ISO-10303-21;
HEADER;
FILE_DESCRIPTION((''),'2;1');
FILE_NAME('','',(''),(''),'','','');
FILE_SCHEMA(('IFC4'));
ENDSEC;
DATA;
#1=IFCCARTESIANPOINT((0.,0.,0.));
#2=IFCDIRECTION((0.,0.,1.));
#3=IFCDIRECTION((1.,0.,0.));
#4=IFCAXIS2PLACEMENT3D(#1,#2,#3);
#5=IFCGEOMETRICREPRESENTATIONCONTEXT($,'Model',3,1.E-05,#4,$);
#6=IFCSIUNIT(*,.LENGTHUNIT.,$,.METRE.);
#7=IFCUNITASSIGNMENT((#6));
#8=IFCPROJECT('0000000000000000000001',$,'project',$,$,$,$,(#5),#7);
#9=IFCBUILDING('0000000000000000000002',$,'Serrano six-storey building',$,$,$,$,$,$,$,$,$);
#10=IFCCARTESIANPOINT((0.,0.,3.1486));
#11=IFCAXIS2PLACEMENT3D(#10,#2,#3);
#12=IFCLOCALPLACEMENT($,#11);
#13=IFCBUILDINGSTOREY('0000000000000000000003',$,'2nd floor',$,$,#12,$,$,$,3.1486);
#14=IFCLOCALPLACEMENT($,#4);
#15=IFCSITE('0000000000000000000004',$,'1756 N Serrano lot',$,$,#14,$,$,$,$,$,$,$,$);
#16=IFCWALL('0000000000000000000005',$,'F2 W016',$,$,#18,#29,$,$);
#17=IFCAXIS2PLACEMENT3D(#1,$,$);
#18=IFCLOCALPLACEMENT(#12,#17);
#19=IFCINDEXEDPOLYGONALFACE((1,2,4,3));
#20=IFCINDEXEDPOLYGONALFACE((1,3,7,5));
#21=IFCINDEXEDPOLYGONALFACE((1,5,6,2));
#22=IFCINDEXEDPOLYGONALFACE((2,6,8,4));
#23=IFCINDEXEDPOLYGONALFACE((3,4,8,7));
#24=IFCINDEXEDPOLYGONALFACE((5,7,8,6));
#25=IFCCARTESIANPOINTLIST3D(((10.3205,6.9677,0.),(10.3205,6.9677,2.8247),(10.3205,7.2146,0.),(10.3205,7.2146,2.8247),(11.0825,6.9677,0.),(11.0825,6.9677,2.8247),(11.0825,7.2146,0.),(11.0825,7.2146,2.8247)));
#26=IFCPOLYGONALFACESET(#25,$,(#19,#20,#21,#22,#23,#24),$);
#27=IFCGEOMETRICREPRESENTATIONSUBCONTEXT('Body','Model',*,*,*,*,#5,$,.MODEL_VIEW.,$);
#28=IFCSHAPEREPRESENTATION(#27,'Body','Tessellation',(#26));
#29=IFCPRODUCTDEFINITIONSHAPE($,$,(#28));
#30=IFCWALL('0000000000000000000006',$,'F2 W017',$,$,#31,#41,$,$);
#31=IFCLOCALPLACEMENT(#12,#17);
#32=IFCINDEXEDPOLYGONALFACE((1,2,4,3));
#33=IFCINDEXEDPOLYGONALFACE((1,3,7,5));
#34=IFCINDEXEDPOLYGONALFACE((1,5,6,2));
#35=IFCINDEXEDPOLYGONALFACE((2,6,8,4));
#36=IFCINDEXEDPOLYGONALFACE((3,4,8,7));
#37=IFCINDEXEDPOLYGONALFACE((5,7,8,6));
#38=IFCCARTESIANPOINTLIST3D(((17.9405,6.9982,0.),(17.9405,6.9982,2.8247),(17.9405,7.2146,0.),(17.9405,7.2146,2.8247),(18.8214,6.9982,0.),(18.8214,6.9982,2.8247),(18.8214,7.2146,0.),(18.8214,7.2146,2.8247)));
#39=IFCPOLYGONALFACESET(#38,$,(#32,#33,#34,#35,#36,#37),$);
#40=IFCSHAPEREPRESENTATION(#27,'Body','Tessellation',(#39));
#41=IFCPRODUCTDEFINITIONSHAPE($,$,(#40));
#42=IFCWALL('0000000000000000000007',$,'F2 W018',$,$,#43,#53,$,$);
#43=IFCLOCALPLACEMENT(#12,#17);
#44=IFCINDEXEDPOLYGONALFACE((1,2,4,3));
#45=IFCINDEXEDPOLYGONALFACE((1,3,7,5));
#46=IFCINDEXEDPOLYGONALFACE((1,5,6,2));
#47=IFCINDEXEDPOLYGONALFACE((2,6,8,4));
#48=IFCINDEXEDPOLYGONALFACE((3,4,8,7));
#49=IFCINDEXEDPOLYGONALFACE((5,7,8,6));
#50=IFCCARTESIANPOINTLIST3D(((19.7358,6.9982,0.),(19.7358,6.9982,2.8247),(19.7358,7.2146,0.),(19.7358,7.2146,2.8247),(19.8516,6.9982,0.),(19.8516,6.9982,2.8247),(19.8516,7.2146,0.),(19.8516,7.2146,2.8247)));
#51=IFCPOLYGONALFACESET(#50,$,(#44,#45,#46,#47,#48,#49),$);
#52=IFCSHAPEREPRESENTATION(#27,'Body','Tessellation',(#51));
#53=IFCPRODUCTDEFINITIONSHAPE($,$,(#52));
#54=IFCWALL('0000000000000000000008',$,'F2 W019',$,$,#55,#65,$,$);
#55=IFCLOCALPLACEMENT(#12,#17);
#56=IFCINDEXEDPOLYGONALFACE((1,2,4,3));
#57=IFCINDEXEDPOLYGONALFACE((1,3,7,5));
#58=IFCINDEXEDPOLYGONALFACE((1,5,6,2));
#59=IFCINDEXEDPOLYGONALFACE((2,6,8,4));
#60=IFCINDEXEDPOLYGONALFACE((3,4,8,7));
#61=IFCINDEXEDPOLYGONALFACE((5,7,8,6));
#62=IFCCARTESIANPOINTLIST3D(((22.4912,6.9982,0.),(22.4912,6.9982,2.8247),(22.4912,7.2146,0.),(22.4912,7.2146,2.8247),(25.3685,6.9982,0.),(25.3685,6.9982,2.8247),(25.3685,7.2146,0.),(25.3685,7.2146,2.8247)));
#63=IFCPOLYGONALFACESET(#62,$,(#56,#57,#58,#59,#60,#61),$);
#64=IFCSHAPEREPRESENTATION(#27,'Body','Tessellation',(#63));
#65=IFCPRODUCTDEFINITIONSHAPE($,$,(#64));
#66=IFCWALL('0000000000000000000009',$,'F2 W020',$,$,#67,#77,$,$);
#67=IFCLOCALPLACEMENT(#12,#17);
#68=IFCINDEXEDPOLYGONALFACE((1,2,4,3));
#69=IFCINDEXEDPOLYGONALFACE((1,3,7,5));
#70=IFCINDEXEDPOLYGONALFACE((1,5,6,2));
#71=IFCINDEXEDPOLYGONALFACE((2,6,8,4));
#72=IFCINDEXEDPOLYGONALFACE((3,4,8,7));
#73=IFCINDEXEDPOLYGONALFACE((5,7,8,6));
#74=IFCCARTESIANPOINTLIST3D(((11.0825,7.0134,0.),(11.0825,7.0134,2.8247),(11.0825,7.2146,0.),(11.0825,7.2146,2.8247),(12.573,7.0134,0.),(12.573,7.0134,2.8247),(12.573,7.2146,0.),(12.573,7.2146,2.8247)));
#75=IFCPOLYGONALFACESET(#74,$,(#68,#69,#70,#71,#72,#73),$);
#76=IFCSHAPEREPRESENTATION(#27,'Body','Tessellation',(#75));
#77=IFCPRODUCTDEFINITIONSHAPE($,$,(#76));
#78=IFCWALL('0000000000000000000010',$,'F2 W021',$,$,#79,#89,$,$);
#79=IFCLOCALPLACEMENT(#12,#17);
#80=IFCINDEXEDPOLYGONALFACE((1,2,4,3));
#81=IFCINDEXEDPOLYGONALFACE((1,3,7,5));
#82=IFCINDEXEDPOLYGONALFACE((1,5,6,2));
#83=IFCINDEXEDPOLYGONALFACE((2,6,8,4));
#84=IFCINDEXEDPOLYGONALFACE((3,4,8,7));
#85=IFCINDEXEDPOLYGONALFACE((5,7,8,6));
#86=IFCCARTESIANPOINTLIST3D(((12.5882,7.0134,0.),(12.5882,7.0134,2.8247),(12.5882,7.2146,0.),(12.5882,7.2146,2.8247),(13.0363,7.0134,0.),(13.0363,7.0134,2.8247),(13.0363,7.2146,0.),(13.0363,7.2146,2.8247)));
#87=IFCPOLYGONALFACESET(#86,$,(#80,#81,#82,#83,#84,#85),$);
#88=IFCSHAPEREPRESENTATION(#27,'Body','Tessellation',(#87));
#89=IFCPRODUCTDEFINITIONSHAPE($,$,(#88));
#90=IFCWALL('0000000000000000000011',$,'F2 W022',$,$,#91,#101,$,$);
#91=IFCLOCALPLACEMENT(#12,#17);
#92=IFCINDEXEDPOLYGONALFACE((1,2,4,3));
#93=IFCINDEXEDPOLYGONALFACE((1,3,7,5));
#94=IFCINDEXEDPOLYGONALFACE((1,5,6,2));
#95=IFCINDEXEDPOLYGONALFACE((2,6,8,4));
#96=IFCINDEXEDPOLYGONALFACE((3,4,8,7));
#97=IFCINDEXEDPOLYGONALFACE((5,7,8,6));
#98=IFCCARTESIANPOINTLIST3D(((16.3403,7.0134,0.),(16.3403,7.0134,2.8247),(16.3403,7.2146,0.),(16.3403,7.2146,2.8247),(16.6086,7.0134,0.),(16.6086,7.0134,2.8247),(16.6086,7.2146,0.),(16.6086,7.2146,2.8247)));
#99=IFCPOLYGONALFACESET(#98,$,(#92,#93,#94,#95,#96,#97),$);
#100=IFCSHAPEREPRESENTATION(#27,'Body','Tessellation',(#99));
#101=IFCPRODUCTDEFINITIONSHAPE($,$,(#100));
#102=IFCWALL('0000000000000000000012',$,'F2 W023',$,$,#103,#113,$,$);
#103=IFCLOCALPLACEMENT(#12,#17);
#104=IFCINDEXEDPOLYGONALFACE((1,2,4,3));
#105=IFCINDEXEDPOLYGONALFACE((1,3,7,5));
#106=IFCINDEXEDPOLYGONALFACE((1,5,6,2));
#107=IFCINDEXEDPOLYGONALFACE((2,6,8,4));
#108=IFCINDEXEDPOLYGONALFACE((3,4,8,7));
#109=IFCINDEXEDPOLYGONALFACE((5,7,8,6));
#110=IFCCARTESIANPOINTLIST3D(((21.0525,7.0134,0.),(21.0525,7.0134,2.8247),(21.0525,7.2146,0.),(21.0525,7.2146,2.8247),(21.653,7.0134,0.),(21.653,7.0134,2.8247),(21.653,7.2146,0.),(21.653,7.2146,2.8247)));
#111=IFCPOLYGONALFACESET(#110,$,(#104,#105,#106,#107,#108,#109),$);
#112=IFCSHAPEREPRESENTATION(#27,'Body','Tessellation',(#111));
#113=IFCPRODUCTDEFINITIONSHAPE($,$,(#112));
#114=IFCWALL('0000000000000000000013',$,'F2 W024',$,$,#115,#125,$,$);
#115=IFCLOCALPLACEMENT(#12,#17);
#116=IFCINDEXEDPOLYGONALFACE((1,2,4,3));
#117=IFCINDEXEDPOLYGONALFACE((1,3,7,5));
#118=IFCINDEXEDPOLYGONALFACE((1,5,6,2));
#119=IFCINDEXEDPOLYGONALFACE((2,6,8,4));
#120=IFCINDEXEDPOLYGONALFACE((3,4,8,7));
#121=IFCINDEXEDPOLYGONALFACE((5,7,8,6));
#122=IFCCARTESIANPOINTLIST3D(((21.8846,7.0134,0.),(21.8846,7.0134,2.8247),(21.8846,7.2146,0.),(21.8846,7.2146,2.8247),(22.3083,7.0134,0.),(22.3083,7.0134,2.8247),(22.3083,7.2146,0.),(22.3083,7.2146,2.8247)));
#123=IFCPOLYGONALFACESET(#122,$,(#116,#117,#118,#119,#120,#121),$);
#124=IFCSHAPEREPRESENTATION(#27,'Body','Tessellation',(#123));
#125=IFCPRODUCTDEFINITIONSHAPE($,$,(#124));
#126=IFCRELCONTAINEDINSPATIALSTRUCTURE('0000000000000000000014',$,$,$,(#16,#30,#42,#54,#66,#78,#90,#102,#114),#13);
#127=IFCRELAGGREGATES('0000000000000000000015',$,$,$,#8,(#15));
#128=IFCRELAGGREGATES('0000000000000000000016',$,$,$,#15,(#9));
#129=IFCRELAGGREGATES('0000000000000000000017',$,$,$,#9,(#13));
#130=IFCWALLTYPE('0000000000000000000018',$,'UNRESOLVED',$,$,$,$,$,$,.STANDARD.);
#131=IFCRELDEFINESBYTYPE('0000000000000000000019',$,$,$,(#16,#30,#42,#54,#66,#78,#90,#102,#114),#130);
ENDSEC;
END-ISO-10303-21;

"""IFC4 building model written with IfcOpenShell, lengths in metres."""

from ifc_helpers import new_model, si_unit, frame, origin_with_axes, place, context, subcontext, project, spatial, polyline, outline, extrude, type_object, element, save


model = new_model("IFC4")

# Units and contexts
model_context = context("Model", 3, precision=1e-05, world=origin_with_axes())
body_context = subcontext(model_context, "Body", "Model", "MODEL_VIEW")
ifc_project = project(units=[si_unit("LENGTHUNIT", "METRE")], contexts=[model_context])

# Site, building, storey
site_placement = place(None, origin_with_axes())
site = spatial("IfcSite", under=ifc_project, at=site_placement, Name="1756 N Serrano lot")
building = spatial("IfcBuilding", under=site, Name="Serrano six-storey building")
storey_placement = place(None, frame((0.0, 0.0, 3.1486), z_axis=(0.0, 0.0, 1.0), x_axis=(1.0, 0.0, 0.0)))
storey = spatial("IfcBuildingStorey", under=building, at=storey_placement, Name="2nd floor", Elevation=3.1486)

# Walls
wall_type = type_object("IfcWallType", Name="UNRESOLVED", PredefinedType="STANDARD")
wall_1_placement = place(storey_placement, frame((0.0, 0.0, -3.1486), z_axis=(0.0, 0.0, 1.0), x_axis=(1.0, 0.0, 0.0)))
element("IfcWall", 1, at=wall_1_placement, inside=storey, type_object=wall_type, Name="F2 W016", context=body_context, shape_type="SweptSolid", body=[
    extrude(outline(polyline([(11.0825, 7.2146), (11.0825, 6.9677), (10.3205, 6.9677), (10.3205, 7.2146), (11.0825, 7.2146)])), frame((0.0, 0.0, 3.1486)), (0.0, 0.0, 1.0), 2.8247),
])
wall_2_placement = place(storey_placement, frame((0.0, 0.0, -3.1486), z_axis=(0.0, 0.0, 1.0), x_axis=(1.0, 0.0, 0.0)))
element("IfcWall", 2, at=wall_2_placement, inside=storey, type_object=wall_type, Name="F2 W017", context=body_context, shape_type="SweptSolid", body=[
    extrude(outline(polyline([(18.8214, 7.2146), (18.8214, 6.9982), (17.9405, 6.9982), (17.9405, 7.2146), (18.8214, 7.2146)])), frame((0.0, 0.0, 3.1486)), (0.0, 0.0, 1.0), 2.8247),
])
wall_3_placement = place(storey_placement, frame((0.0, 0.0, -3.1486), z_axis=(0.0, 0.0, 1.0), x_axis=(1.0, 0.0, 0.0)))
element("IfcWall", 3, at=wall_3_placement, inside=storey, type_object=wall_type, Name="F2 W018", context=body_context, shape_type="SweptSolid", body=[
    extrude(outline(polyline([(19.8516, 7.2146), (19.8516, 6.9982), (19.7358, 6.9982), (19.7358, 7.2146), (19.8516, 7.2146)])), frame((0.0, 0.0, 3.1486)), (0.0, 0.0, 1.0), 2.8247),
])
wall_4_placement = place(storey_placement, frame((0.0, 0.0, -3.1486), z_axis=(0.0, 0.0, 1.0), x_axis=(1.0, 0.0, 0.0)))
element("IfcWall", 4, at=wall_4_placement, inside=storey, type_object=wall_type, Name="F2 W019", context=body_context, shape_type="SweptSolid", body=[
    extrude(outline(polyline([(25.3685, 7.2146), (25.3685, 6.9982), (22.4912, 6.9982), (22.4912, 7.2146), (25.3685, 7.2146)])), frame((0.0, 0.0, 3.1486)), (0.0, 0.0, 1.0), 2.8247),
])
wall_5_placement = place(storey_placement, frame((0.0, 0.0, -3.1486), z_axis=(0.0, 0.0, 1.0), x_axis=(1.0, 0.0, 0.0)))
element("IfcWall", 5, at=wall_5_placement, inside=storey, type_object=wall_type, Name="F2 W020", context=body_context, shape_type="SweptSolid", body=[
    extrude(outline(polyline([(12.573, 7.2146), (12.573, 7.0134), (11.0825, 7.0134), (11.0825, 7.2146), (12.573, 7.2146)])), frame((0.0, 0.0, 3.1486)), (0.0, 0.0, 1.0), 2.8247),
])
wall_6_placement = place(storey_placement, frame((0.0, 0.0, -3.1486), z_axis=(0.0, 0.0, 1.0), x_axis=(1.0, 0.0, 0.0)))
element("IfcWall", 6, at=wall_6_placement, inside=storey, type_object=wall_type, Name="F2 W021", context=body_context, shape_type="SweptSolid", body=[
    extrude(outline(polyline([(13.0363, 7.2146), (13.0363, 7.0134), (12.5882, 7.0134), (12.5882, 7.2146), (13.0363, 7.2146)])), frame((0.0, 0.0, 3.1486)), (0.0, 0.0, 1.0), 2.8247),
])
wall_7_placement = place(storey_placement, frame((0.0, 0.0, -3.1486), z_axis=(0.0, 0.0, 1.0), x_axis=(1.0, 0.0, 0.0)))
element("IfcWall", 7, at=wall_7_placement, inside=storey, type_object=wall_type, Name="F2 W022", context=body_context, shape_type="SweptSolid", body=[
    extrude(outline(polyline([(16.6086, 7.2146), (16.6086, 7.0134), (16.3403, 7.0134), (16.3403, 7.2146), (16.6086, 7.2146)])), frame((0.0, 0.0, 3.1486)), (0.0, 0.0, 1.0), 2.8247),
])
wall_8_placement = place(storey_placement, frame((0.0, 0.0, -3.1486), z_axis=(0.0, 0.0, 1.0), x_axis=(1.0, 0.0, 0.0)))
element("IfcWall", 8, at=wall_8_placement, inside=storey, type_object=wall_type, Name="F2 W023", context=body_context, shape_type="SweptSolid", body=[
    extrude(outline(polyline([(21.653, 7.2146), (21.653, 7.0134), (21.0525, 7.0134), (21.0525, 7.2146), (21.653, 7.2146)])), frame((0.0, 0.0, 3.1486)), (0.0, 0.0, 1.0), 2.8247),
])
wall_9_placement = place(storey_placement, frame((0.0, 0.0, -3.1486), z_axis=(0.0, 0.0, 1.0), x_axis=(1.0, 0.0, 0.0)))
element("IfcWall", 9, at=wall_9_placement, inside=storey, type_object=wall_type, Name="F2 W024", context=body_context, shape_type="SweptSolid", body=[
    extrude(outline(polyline([(22.3083, 7.2146), (22.3083, 7.0134), (21.8846, 7.0134), (21.8846, 7.2146), (22.3083, 7.2146)])), frame((0.0, 0.0, 3.1486)), (0.0, 0.0, 1.0), 2.8247),
])

save(model, "model.ifc")
